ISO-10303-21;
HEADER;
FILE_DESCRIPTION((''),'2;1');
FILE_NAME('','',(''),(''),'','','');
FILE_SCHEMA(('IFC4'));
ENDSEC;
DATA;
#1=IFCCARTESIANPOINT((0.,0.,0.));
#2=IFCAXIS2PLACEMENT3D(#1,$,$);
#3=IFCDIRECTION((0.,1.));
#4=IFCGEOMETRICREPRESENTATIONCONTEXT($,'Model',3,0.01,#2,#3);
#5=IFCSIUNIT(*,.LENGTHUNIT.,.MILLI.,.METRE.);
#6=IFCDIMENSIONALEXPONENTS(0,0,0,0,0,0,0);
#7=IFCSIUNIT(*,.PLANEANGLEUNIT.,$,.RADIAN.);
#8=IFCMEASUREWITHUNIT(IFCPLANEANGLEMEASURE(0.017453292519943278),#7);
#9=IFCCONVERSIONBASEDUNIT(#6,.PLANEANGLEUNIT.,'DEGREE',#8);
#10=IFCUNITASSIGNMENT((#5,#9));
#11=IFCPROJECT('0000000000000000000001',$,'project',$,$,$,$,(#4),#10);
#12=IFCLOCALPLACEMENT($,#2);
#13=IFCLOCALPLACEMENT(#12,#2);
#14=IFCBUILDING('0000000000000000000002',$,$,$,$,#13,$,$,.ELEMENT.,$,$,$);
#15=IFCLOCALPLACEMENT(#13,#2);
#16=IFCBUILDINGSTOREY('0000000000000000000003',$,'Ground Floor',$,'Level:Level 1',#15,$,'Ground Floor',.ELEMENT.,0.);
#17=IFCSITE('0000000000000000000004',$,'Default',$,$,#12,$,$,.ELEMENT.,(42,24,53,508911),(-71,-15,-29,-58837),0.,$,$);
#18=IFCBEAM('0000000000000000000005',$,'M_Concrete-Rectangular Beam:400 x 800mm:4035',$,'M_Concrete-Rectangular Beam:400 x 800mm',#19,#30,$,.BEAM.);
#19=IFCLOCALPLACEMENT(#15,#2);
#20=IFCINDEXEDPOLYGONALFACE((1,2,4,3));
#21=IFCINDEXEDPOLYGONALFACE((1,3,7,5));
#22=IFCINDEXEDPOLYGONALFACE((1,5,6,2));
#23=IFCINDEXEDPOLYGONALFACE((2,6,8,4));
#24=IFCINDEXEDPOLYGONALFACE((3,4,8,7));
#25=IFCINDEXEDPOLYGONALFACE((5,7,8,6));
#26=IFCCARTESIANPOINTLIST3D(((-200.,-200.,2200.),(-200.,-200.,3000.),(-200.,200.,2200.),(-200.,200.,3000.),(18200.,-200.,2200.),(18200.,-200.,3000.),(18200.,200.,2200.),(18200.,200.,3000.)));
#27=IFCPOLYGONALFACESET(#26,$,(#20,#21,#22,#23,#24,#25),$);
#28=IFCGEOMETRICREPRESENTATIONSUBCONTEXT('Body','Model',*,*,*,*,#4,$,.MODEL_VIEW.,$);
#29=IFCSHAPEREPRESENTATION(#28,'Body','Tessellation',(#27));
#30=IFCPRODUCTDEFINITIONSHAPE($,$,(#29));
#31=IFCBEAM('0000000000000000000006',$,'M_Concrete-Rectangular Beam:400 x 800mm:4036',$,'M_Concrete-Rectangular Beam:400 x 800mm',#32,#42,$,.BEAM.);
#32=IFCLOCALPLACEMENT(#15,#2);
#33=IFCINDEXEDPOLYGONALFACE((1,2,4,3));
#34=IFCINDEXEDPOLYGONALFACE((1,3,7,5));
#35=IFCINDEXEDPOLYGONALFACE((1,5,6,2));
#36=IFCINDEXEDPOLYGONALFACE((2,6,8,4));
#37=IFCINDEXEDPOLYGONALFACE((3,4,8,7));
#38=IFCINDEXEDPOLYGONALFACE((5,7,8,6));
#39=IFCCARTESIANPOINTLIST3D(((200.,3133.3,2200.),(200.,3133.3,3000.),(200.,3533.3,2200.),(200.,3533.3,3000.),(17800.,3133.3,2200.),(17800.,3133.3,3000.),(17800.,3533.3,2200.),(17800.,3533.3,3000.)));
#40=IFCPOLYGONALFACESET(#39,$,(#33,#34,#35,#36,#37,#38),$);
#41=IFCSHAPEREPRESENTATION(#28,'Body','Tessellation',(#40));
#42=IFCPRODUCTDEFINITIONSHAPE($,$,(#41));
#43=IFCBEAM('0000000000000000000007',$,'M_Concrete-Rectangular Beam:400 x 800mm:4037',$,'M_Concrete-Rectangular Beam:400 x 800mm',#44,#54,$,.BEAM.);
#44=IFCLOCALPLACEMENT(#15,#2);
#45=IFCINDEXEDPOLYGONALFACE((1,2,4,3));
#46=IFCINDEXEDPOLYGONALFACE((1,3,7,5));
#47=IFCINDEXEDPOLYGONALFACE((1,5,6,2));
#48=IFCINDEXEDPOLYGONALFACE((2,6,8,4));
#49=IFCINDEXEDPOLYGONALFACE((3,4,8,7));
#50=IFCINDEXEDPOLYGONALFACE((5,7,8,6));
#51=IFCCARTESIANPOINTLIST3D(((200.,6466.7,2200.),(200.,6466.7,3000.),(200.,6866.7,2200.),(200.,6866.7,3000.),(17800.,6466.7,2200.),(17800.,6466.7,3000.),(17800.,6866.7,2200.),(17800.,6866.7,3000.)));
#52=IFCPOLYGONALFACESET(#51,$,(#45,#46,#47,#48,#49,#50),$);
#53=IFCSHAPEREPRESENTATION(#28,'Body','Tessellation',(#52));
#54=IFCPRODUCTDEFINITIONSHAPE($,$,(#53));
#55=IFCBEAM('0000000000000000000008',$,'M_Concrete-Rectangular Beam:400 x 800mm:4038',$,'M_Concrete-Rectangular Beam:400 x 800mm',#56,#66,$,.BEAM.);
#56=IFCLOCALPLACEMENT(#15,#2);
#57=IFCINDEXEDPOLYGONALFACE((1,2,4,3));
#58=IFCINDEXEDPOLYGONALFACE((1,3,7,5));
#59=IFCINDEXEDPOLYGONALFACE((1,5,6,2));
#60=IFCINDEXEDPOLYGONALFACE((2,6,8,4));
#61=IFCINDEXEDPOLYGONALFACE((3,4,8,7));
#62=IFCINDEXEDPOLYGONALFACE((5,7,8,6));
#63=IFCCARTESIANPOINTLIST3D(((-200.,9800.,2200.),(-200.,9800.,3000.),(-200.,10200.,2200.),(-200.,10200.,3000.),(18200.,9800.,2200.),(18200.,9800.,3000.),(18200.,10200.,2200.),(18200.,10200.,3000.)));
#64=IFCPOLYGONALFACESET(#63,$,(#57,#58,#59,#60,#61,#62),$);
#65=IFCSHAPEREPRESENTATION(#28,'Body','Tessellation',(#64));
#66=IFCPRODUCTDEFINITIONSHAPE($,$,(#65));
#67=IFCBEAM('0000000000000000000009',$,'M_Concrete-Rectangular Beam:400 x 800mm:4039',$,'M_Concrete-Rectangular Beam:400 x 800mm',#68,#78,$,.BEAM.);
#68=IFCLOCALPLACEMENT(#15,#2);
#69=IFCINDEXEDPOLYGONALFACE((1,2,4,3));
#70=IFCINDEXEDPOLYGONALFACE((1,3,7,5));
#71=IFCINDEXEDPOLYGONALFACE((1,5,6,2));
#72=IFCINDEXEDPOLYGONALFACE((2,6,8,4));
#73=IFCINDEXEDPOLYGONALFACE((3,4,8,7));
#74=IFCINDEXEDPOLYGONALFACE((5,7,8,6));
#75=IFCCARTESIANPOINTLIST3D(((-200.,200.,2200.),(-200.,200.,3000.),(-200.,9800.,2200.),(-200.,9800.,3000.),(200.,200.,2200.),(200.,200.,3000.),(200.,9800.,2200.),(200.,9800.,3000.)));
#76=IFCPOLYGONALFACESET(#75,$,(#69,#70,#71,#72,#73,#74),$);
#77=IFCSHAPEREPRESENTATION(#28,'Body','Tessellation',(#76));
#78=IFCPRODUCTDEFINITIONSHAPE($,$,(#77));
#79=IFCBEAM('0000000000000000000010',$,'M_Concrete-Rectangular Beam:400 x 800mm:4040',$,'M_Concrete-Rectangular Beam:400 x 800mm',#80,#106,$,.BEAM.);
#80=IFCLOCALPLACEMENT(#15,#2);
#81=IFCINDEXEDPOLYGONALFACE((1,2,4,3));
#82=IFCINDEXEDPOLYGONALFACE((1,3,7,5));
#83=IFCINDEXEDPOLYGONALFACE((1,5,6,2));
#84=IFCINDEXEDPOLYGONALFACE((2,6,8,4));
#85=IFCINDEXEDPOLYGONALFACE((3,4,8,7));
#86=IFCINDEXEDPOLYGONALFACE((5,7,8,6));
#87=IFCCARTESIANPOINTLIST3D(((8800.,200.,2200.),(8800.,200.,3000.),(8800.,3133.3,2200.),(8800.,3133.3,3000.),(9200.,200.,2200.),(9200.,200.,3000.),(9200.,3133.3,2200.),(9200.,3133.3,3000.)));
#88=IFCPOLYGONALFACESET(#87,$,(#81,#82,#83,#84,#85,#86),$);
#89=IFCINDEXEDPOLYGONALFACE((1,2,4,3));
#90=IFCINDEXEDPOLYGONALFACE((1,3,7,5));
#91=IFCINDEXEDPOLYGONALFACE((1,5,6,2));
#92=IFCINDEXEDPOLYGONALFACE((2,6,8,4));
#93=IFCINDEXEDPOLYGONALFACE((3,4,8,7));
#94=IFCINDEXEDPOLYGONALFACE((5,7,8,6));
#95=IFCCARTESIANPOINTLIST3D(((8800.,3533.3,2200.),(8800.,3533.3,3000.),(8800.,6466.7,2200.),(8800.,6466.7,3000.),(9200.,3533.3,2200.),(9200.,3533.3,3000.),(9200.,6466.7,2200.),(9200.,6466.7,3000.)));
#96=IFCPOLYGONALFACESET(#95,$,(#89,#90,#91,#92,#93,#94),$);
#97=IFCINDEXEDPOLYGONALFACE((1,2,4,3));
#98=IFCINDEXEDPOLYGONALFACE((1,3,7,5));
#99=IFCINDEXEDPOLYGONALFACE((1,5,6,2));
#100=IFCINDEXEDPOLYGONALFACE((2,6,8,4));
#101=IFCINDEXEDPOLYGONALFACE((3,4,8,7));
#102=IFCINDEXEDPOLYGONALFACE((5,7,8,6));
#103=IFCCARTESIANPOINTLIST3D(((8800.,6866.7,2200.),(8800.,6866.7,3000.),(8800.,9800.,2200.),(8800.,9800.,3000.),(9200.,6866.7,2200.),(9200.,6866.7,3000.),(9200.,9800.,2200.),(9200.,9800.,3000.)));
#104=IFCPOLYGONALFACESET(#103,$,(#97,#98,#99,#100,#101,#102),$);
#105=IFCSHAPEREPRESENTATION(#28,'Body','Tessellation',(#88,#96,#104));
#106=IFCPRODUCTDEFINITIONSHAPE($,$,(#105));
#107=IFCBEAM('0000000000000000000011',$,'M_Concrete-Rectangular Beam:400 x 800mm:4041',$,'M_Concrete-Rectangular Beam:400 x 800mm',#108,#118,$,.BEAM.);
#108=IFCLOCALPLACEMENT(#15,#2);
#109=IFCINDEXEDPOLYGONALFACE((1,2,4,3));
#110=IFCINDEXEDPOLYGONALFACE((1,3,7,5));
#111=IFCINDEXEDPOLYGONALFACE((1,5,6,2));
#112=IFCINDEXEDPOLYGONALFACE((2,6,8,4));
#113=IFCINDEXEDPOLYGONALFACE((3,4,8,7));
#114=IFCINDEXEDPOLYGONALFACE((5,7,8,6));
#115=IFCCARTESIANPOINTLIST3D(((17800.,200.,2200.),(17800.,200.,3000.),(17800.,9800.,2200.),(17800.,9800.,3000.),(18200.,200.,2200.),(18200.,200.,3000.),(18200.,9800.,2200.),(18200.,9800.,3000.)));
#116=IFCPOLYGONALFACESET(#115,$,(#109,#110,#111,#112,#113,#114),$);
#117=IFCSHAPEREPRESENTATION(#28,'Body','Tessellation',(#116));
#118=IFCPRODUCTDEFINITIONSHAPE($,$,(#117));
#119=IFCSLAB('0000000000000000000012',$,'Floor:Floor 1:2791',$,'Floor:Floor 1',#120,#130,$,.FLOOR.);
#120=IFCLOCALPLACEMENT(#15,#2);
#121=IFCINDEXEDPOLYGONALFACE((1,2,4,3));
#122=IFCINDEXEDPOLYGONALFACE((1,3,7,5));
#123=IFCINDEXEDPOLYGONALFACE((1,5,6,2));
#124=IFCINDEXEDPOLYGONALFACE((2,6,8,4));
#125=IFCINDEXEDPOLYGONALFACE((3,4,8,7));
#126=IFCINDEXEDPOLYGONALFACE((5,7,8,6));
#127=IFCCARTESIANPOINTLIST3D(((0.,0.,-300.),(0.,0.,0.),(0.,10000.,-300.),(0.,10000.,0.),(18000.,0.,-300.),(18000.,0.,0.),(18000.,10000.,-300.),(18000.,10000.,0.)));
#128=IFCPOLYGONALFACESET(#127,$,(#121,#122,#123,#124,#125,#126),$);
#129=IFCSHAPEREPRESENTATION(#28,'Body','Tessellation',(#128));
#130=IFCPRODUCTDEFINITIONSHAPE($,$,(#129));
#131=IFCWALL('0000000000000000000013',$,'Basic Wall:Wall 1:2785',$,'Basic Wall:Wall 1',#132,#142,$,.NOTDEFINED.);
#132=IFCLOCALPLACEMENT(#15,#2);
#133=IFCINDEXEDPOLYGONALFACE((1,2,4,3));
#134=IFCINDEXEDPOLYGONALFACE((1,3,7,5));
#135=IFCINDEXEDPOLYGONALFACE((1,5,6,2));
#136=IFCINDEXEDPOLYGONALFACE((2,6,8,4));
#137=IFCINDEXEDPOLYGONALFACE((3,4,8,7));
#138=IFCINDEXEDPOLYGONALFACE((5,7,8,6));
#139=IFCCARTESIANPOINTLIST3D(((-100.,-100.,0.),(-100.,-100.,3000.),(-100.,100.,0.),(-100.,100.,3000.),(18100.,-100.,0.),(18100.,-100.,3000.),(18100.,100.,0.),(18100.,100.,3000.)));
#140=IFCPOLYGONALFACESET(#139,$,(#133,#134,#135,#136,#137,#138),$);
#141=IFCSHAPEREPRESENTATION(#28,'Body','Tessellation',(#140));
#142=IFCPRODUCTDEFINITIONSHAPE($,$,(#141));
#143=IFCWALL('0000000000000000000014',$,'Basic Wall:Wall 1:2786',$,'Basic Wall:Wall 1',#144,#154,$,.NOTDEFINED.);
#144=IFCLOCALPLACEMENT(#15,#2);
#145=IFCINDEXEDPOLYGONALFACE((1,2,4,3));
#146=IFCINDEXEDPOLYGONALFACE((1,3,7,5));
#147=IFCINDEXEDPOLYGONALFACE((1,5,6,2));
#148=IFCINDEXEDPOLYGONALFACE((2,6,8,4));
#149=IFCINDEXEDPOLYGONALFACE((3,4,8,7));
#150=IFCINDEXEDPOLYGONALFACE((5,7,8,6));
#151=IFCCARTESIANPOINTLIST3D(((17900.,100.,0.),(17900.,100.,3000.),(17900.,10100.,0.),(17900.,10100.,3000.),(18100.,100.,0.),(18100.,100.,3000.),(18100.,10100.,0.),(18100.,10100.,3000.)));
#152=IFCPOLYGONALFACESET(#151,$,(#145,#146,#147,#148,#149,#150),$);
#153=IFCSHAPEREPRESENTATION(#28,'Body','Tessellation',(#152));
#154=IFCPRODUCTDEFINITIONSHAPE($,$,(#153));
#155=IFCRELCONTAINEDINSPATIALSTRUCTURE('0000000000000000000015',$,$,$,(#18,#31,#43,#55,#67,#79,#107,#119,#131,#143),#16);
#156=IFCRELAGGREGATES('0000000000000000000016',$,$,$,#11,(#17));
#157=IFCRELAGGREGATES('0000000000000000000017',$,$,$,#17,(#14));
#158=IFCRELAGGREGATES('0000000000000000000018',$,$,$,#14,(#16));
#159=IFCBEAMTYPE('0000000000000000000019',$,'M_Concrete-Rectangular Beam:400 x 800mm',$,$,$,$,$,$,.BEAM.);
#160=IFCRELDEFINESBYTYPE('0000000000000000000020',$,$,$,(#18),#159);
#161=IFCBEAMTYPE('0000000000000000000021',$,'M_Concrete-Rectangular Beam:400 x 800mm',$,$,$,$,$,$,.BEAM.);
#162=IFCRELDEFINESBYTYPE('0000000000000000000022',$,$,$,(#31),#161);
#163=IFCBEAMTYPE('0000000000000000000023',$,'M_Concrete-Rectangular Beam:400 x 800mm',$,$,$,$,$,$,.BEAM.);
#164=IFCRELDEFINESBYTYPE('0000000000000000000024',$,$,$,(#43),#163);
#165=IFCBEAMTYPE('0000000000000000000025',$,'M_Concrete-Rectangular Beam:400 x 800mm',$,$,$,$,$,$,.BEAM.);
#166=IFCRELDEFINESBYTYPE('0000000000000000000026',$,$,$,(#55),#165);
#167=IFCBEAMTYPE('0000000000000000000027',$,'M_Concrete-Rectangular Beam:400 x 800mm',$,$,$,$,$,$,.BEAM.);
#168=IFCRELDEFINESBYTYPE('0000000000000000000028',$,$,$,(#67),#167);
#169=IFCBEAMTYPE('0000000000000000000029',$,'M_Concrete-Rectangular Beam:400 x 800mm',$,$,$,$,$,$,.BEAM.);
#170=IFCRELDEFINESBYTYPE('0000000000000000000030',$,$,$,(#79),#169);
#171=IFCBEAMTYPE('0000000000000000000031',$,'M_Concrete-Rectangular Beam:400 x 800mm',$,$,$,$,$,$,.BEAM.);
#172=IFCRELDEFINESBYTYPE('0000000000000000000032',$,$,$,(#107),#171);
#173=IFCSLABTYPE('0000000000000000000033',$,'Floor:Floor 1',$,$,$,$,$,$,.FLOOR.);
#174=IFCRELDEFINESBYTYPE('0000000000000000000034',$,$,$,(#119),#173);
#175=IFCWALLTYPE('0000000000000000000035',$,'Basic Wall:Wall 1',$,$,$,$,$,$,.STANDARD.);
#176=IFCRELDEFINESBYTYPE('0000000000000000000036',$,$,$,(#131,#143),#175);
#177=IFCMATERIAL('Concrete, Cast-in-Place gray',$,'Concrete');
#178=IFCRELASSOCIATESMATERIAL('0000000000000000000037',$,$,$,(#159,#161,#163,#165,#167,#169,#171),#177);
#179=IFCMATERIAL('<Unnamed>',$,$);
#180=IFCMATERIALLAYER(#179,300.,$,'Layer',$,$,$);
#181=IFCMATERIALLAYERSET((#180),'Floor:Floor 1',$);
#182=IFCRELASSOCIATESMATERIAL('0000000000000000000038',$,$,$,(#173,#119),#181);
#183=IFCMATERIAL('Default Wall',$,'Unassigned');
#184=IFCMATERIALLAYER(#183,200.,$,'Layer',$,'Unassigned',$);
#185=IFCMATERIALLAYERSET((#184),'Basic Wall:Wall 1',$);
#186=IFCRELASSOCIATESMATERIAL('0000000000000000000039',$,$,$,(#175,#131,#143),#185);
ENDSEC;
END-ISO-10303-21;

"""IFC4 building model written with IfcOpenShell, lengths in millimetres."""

from ifc_helpers import new_model, entity, si_unit, converted_unit, direction, frame, frame_2d, origin, origin_2d_with_axis, place, context, subcontext, project, spatial, rectangle, extrude, source, transform, mapped, material, layer, layer_set, layer_usage, material_profile, profile_set, type_object, type_shapes, element, save


model = new_model("IFC4")

# Units and contexts
model_context = context("Model", 3, precision=0.01, world=origin(), true_north=direction((0.0, 1.0)))
body_context = subcontext(model_context, "Body", "Model", "MODEL_VIEW")
ifc_project = project(units=[si_unit("LENGTHUNIT", "METRE", prefix="MILLI"), converted_unit("PLANEANGLEUNIT", "DEGREE", entity("IfcPlaneAngleMeasure", 0.017453292519943278), si_unit("PLANEANGLEUNIT", "RADIAN"), dimensions=[0, 0, 0, 0, 0, 0, 0])], contexts=[model_context])

# Site, building, storey
site_placement = place(None, origin())
site = spatial("IfcSite", under=ifc_project, at=site_placement, Name="Default", CompositionType="ELEMENT", RefLatitude=(42, 24, 53, 508911), RefLongitude=(-71, -15, -29, -58837), RefElevation=0.0)
building_placement = place(site_placement, origin())
building = spatial("IfcBuilding", under=site, at=building_placement, CompositionType="ELEMENT")
storey_placement = place(building_placement, origin())
storey = spatial("IfcBuildingStorey", under=building, at=storey_placement, Name="Ground Floor", ObjectType="Level:Level 1", LongName="Ground Floor", CompositionType="ELEMENT", Elevation=0.0)

# Shared definitions
ifc_material_1 = material(Name="Default Wall", Category="Unassigned")

# Beams
ifc_material_2 = material(Name="Concrete, Cast-in-Place gray", Category="Concrete")
ifc_material_profile_1 = material_profile(ifc_material_2, rectangle(XDim=800.0, YDim=400.0, at=origin_2d_with_axis()), Name="400 x 800mm")
ifc_profile_set_1 = profile_set([ifc_material_profile_1], Name="400 x 800mm")
beam_type_1 = type_object("IfcBeamType", Name="M_Concrete-Rectangular Beam:400 x 800mm", PredefinedType="BEAM", material=ifc_profile_set_1)
shared_shape_1 = source(origin(), body_context, "Body", "SweptSolid", [
    extrude(rectangle(XDim=800.0, YDim=400.0, at=origin_2d_with_axis()), frame((-200.0, 0.0, 2600.0), z_axis=(1.0, 0.0, 0.0), x_axis=(0.0, 0.0, -1.0)), (0.0, 0.0, 1.0), 18400.0),
])
type_shapes(beam_type_1, [shared_shape_1])
beam_1_placement = place(storey_placement, origin())
element("IfcBeam", 1, at=beam_1_placement, inside=storey, type_object=beam_type_1, Name="M_Concrete-Rectangular Beam:400 x 800mm:4035", ObjectType="M_Concrete-Rectangular Beam:400 x 800mm", PredefinedType="BEAM", context=body_context, shape_type="MappedRepresentation", body=[
    mapped(shared_shape_1, transform((0.0, 0.0, 0.0), scale=1.0)),
])
beam_type_2 = type_object("IfcBeamType", Name="M_Concrete-Rectangular Beam:400 x 800mm", PredefinedType="BEAM", material=ifc_profile_set_1)
shared_shape_2 = source(origin(), body_context, "Body", "SweptSolid", [
    extrude(rectangle(XDim=800.0, YDim=400.0, at=frame_2d((0.0, 0.0), x_axis=(1.0, 0.0))), frame((200.0, 3333.3, 2600.0), z_axis=(1.0, 0.0, 0.0), x_axis=(0.0, 0.0, -1.0)), (0.0, 0.0, 1.0), 17600.0),
])
type_shapes(beam_type_2, [shared_shape_2])
beam_2_placement = place(storey_placement, origin())
element("IfcBeam", 2, at=beam_2_placement, inside=storey, type_object=beam_type_2, Name="M_Concrete-Rectangular Beam:400 x 800mm:4036", ObjectType="M_Concrete-Rectangular Beam:400 x 800mm", PredefinedType="BEAM", context=body_context, shape_type="MappedRepresentation", body=[
    mapped(shared_shape_2, transform((0.0, 0.0, 0.0), scale=1.0)),
])
beam_type_3 = type_object("IfcBeamType", Name="M_Concrete-Rectangular Beam:400 x 800mm", PredefinedType="BEAM", material=ifc_profile_set_1)
shared_shape_3 = source(origin(), body_context, "Body", "SweptSolid", [
    extrude(rectangle(XDim=800.0, YDim=400.0, at=frame_2d((0.0, 0.0), x_axis=(1.0, 0.0))), frame((200.0, 6666.7, 2600.0), z_axis=(1.0, 0.0, 0.0), x_axis=(0.0, 0.0, -1.0)), (0.0, 0.0, 1.0), 17600.0),
])
type_shapes(beam_type_3, [shared_shape_3])
beam_3_placement = place(storey_placement, origin())
element("IfcBeam", 3, at=beam_3_placement, inside=storey, type_object=beam_type_3, Name="M_Concrete-Rectangular Beam:400 x 800mm:4037", ObjectType="M_Concrete-Rectangular Beam:400 x 800mm", PredefinedType="BEAM", context=body_context, shape_type="MappedRepresentation", body=[
    mapped(shared_shape_3, transform((0.0, 0.0, 0.0), scale=1.0)),
])
beam_type_4 = type_object("IfcBeamType", Name="M_Concrete-Rectangular Beam:400 x 800mm", PredefinedType="BEAM", material=ifc_profile_set_1)
shared_shape_4 = source(origin(), body_context, "Body", "SweptSolid", [
    extrude(rectangle(XDim=800.0, YDim=400.0, at=frame_2d((0.0, 0.0), x_axis=(1.0, 0.0))), frame((-200.0, 10000.0, 2600.0), z_axis=(1.0, 0.0, 0.0), x_axis=(0.0, 0.0, -1.0)), (0.0, 0.0, 1.0), 18400.0),
])
type_shapes(beam_type_4, [shared_shape_4])
beam_4_placement = place(storey_placement, origin())
element("IfcBeam", 4, at=beam_4_placement, inside=storey, type_object=beam_type_4, Name="M_Concrete-Rectangular Beam:400 x 800mm:4038", ObjectType="M_Concrete-Rectangular Beam:400 x 800mm", PredefinedType="BEAM", context=body_context, shape_type="MappedRepresentation", body=[
    mapped(shared_shape_4, transform((0.0, 0.0, 0.0), scale=1.0)),
])
beam_type_5 = type_object("IfcBeamType", Name="M_Concrete-Rectangular Beam:400 x 800mm", PredefinedType="BEAM", material=ifc_profile_set_1)
shared_shape_5 = source(origin(), body_context, "Body", "SweptSolid", [
    extrude(rectangle(XDim=800.0, YDim=400.0, at=frame_2d((0.0, 0.0), x_axis=(0.0, 1.0))), frame((0.0, 200.0, 2600.0), z_axis=(0.0, 1.0, 0.0), x_axis=(-1.0, 0.0, 0.0)), (0.0, 0.0, 1.0), 9600.0),
])
type_shapes(beam_type_5, [shared_shape_5])
beam_5_placement = place(storey_placement, origin())
element("IfcBeam", 5, at=beam_5_placement, inside=storey, type_object=beam_type_5, Name="M_Concrete-Rectangular Beam:400 x 800mm:4039", ObjectType="M_Concrete-Rectangular Beam:400 x 800mm", PredefinedType="BEAM", context=body_context, shape_type="MappedRepresentation", body=[
    mapped(shared_shape_5, transform((0.0, 0.0, 0.0), scale=1.0)),
])
beam_type_6 = type_object("IfcBeamType", Name="M_Concrete-Rectangular Beam:400 x 800mm", PredefinedType="BEAM", material=ifc_profile_set_1)
shared_shape_6 = source(origin(), body_context, "Body", "SweptSolid", [
    extrude(rectangle(XDim=800.0, YDim=400.0, at=frame_2d((0.0, 0.0), x_axis=(0.0, 1.0))), frame((9000.0, 200.0, 2600.0), z_axis=(0.0, 1.0, 0.0), x_axis=(-1.0, 0.0, 0.0)), (0.0, 0.0, 1.0), 2933.3),
    extrude(rectangle(XDim=800.0, YDim=400.0, at=frame_2d((0.0, 0.0), x_axis=(0.0, 1.0))), frame((9000.0, 3533.3, 2600.0), z_axis=(0.0, 1.0, 0.0), x_axis=(-1.0, 0.0, 0.0)), (0.0, 0.0, 1.0), 2933.3),
    extrude(rectangle(XDim=800.0, YDim=400.0, at=frame_2d((0.0, 0.0), x_axis=(0.0, 1.0))), frame((9000.0, 6866.7, 2600.0), z_axis=(0.0, 1.0, 0.0), x_axis=(-1.0, 0.0, 0.0)), (0.0, 0.0, 1.0), 2933.3),
])
type_shapes(beam_type_6, [shared_shape_6])
beam_6_placement = place(storey_placement, origin())
element("IfcBeam", 6, at=beam_6_placement, inside=storey, type_object=beam_type_6, Name="M_Concrete-Rectangular Beam:400 x 800mm:4040", ObjectType="M_Concrete-Rectangular Beam:400 x 800mm", PredefinedType="BEAM", context=body_context, shape_type="MappedRepresentation", body=[
    mapped(shared_shape_6, transform((0.0, 0.0, 0.0), scale=1.0)),
])
beam_type_7 = type_object("IfcBeamType", Name="M_Concrete-Rectangular Beam:400 x 800mm", PredefinedType="BEAM", material=ifc_profile_set_1)
shared_shape_7 = source(origin(), body_context, "Body", "SweptSolid", [
    extrude(rectangle(XDim=800.0, YDim=400.0, at=frame_2d((0.0, 0.0), x_axis=(0.0, 1.0))), frame((18000.0, 200.0, 2600.0), z_axis=(0.0, 1.0, 0.0), x_axis=(-1.0, 0.0, 0.0)), (0.0, 0.0, 1.0), 9600.0),
])
type_shapes(beam_type_7, [shared_shape_7])
beam_7_placement = place(storey_placement, origin())
element("IfcBeam", 7, at=beam_7_placement, inside=storey, type_object=beam_type_7, Name="M_Concrete-Rectangular Beam:400 x 800mm:4041", ObjectType="M_Concrete-Rectangular Beam:400 x 800mm", PredefinedType="BEAM", context=body_context, shape_type="MappedRepresentation", body=[
    mapped(shared_shape_7, transform((0.0, 0.0, 0.0), scale=1.0)),
])

# Slab
ifc_material_3 = material(Name="<Unnamed>")
ifc_layer_1 = layer(ifc_material_3, 300.0, Name="Layer")
ifc_layer_set_1 = layer_set([ifc_layer_1], Name="Floor:Floor 1")
ifc_layer_usage_1 = layer_usage(ifc_layer_set_1, "AXIS3", "POSITIVE", 0.0)
slab_type = type_object("IfcSlabType", Name="Floor:Floor 1", PredefinedType="FLOOR", material=ifc_layer_set_1)
slab_placement = place(storey_placement, origin())
element("IfcSlab", 8, at=slab_placement, inside=storey, type_object=slab_type, material=ifc_layer_usage_1, Name="Floor:Floor 1:2791", ObjectType="Floor:Floor 1", PredefinedType="FLOOR", context=body_context, shape_type="SweptSolid", body=[
    extrude(rectangle(XDim=10000.0, YDim=18000.0, at=origin_2d_with_axis()), frame((9000.0, 5000.0, 0.0), z_axis=(0.0, 0.0, -1.0), x_axis=(0.0, 1.0, 0.0)), (0.0, 0.0, 1.0), 300.0),
])

# Walls
ifc_layer_2 = layer(ifc_material_1, 200.0, Name="Layer", Category="Unassigned")
ifc_layer_set_2 = layer_set([ifc_layer_2], Name="Basic Wall:Wall 1")
ifc_layer_usage_2 = layer_usage(ifc_layer_set_2, "AXIS2", "NEGATIVE", 100.0)
wall_type = type_object("IfcWallType", Name="Basic Wall:Wall 1", PredefinedType="STANDARD", material=ifc_layer_set_2)
wall_1_placement = place(storey_placement, frame((-100.0, 0.0, 0.0)))
element("IfcWall", 9, at=wall_1_placement, inside=storey, type_object=wall_type, material=ifc_layer_usage_2, Name="Basic Wall:Wall 1:2785", ObjectType="Basic Wall:Wall 1", PredefinedType="NOTDEFINED", context=body_context, shape_type="SweptSolid", body=[
    extrude(rectangle(XDim=18200.0, YDim=200.0, at=frame_2d((9100.0, 0.0), x_axis=(-1.0, 0.0))), origin(), (0.0, 0.0, 1.0), 3000.0),
])
ifc_layer_usage_3 = layer_usage(ifc_layer_set_2, "AXIS2", "NEGATIVE", 100.0)
wall_2_placement = place(storey_placement, frame((18000.0, 100.0, 0.0), z_axis=(0.0, 0.0, 1.0), x_axis=(0.0, 1.0, 0.0)))
element("IfcWall", 10, at=wall_2_placement, inside=storey, type_object=wall_type, material=ifc_layer_usage_3, Name="Basic Wall:Wall 1:2786", ObjectType="Basic Wall:Wall 1", PredefinedType="NOTDEFINED", context=body_context, shape_type="SweptSolid", body=[
    extrude(rectangle(XDim=10000.0, YDim=200.0, at=frame_2d((5000.0, 0.0), x_axis=(-1.0, 0.0))), origin(), (0.0, 0.0, 1.0), 3000.0),
])

save(model, "model.ifc")
